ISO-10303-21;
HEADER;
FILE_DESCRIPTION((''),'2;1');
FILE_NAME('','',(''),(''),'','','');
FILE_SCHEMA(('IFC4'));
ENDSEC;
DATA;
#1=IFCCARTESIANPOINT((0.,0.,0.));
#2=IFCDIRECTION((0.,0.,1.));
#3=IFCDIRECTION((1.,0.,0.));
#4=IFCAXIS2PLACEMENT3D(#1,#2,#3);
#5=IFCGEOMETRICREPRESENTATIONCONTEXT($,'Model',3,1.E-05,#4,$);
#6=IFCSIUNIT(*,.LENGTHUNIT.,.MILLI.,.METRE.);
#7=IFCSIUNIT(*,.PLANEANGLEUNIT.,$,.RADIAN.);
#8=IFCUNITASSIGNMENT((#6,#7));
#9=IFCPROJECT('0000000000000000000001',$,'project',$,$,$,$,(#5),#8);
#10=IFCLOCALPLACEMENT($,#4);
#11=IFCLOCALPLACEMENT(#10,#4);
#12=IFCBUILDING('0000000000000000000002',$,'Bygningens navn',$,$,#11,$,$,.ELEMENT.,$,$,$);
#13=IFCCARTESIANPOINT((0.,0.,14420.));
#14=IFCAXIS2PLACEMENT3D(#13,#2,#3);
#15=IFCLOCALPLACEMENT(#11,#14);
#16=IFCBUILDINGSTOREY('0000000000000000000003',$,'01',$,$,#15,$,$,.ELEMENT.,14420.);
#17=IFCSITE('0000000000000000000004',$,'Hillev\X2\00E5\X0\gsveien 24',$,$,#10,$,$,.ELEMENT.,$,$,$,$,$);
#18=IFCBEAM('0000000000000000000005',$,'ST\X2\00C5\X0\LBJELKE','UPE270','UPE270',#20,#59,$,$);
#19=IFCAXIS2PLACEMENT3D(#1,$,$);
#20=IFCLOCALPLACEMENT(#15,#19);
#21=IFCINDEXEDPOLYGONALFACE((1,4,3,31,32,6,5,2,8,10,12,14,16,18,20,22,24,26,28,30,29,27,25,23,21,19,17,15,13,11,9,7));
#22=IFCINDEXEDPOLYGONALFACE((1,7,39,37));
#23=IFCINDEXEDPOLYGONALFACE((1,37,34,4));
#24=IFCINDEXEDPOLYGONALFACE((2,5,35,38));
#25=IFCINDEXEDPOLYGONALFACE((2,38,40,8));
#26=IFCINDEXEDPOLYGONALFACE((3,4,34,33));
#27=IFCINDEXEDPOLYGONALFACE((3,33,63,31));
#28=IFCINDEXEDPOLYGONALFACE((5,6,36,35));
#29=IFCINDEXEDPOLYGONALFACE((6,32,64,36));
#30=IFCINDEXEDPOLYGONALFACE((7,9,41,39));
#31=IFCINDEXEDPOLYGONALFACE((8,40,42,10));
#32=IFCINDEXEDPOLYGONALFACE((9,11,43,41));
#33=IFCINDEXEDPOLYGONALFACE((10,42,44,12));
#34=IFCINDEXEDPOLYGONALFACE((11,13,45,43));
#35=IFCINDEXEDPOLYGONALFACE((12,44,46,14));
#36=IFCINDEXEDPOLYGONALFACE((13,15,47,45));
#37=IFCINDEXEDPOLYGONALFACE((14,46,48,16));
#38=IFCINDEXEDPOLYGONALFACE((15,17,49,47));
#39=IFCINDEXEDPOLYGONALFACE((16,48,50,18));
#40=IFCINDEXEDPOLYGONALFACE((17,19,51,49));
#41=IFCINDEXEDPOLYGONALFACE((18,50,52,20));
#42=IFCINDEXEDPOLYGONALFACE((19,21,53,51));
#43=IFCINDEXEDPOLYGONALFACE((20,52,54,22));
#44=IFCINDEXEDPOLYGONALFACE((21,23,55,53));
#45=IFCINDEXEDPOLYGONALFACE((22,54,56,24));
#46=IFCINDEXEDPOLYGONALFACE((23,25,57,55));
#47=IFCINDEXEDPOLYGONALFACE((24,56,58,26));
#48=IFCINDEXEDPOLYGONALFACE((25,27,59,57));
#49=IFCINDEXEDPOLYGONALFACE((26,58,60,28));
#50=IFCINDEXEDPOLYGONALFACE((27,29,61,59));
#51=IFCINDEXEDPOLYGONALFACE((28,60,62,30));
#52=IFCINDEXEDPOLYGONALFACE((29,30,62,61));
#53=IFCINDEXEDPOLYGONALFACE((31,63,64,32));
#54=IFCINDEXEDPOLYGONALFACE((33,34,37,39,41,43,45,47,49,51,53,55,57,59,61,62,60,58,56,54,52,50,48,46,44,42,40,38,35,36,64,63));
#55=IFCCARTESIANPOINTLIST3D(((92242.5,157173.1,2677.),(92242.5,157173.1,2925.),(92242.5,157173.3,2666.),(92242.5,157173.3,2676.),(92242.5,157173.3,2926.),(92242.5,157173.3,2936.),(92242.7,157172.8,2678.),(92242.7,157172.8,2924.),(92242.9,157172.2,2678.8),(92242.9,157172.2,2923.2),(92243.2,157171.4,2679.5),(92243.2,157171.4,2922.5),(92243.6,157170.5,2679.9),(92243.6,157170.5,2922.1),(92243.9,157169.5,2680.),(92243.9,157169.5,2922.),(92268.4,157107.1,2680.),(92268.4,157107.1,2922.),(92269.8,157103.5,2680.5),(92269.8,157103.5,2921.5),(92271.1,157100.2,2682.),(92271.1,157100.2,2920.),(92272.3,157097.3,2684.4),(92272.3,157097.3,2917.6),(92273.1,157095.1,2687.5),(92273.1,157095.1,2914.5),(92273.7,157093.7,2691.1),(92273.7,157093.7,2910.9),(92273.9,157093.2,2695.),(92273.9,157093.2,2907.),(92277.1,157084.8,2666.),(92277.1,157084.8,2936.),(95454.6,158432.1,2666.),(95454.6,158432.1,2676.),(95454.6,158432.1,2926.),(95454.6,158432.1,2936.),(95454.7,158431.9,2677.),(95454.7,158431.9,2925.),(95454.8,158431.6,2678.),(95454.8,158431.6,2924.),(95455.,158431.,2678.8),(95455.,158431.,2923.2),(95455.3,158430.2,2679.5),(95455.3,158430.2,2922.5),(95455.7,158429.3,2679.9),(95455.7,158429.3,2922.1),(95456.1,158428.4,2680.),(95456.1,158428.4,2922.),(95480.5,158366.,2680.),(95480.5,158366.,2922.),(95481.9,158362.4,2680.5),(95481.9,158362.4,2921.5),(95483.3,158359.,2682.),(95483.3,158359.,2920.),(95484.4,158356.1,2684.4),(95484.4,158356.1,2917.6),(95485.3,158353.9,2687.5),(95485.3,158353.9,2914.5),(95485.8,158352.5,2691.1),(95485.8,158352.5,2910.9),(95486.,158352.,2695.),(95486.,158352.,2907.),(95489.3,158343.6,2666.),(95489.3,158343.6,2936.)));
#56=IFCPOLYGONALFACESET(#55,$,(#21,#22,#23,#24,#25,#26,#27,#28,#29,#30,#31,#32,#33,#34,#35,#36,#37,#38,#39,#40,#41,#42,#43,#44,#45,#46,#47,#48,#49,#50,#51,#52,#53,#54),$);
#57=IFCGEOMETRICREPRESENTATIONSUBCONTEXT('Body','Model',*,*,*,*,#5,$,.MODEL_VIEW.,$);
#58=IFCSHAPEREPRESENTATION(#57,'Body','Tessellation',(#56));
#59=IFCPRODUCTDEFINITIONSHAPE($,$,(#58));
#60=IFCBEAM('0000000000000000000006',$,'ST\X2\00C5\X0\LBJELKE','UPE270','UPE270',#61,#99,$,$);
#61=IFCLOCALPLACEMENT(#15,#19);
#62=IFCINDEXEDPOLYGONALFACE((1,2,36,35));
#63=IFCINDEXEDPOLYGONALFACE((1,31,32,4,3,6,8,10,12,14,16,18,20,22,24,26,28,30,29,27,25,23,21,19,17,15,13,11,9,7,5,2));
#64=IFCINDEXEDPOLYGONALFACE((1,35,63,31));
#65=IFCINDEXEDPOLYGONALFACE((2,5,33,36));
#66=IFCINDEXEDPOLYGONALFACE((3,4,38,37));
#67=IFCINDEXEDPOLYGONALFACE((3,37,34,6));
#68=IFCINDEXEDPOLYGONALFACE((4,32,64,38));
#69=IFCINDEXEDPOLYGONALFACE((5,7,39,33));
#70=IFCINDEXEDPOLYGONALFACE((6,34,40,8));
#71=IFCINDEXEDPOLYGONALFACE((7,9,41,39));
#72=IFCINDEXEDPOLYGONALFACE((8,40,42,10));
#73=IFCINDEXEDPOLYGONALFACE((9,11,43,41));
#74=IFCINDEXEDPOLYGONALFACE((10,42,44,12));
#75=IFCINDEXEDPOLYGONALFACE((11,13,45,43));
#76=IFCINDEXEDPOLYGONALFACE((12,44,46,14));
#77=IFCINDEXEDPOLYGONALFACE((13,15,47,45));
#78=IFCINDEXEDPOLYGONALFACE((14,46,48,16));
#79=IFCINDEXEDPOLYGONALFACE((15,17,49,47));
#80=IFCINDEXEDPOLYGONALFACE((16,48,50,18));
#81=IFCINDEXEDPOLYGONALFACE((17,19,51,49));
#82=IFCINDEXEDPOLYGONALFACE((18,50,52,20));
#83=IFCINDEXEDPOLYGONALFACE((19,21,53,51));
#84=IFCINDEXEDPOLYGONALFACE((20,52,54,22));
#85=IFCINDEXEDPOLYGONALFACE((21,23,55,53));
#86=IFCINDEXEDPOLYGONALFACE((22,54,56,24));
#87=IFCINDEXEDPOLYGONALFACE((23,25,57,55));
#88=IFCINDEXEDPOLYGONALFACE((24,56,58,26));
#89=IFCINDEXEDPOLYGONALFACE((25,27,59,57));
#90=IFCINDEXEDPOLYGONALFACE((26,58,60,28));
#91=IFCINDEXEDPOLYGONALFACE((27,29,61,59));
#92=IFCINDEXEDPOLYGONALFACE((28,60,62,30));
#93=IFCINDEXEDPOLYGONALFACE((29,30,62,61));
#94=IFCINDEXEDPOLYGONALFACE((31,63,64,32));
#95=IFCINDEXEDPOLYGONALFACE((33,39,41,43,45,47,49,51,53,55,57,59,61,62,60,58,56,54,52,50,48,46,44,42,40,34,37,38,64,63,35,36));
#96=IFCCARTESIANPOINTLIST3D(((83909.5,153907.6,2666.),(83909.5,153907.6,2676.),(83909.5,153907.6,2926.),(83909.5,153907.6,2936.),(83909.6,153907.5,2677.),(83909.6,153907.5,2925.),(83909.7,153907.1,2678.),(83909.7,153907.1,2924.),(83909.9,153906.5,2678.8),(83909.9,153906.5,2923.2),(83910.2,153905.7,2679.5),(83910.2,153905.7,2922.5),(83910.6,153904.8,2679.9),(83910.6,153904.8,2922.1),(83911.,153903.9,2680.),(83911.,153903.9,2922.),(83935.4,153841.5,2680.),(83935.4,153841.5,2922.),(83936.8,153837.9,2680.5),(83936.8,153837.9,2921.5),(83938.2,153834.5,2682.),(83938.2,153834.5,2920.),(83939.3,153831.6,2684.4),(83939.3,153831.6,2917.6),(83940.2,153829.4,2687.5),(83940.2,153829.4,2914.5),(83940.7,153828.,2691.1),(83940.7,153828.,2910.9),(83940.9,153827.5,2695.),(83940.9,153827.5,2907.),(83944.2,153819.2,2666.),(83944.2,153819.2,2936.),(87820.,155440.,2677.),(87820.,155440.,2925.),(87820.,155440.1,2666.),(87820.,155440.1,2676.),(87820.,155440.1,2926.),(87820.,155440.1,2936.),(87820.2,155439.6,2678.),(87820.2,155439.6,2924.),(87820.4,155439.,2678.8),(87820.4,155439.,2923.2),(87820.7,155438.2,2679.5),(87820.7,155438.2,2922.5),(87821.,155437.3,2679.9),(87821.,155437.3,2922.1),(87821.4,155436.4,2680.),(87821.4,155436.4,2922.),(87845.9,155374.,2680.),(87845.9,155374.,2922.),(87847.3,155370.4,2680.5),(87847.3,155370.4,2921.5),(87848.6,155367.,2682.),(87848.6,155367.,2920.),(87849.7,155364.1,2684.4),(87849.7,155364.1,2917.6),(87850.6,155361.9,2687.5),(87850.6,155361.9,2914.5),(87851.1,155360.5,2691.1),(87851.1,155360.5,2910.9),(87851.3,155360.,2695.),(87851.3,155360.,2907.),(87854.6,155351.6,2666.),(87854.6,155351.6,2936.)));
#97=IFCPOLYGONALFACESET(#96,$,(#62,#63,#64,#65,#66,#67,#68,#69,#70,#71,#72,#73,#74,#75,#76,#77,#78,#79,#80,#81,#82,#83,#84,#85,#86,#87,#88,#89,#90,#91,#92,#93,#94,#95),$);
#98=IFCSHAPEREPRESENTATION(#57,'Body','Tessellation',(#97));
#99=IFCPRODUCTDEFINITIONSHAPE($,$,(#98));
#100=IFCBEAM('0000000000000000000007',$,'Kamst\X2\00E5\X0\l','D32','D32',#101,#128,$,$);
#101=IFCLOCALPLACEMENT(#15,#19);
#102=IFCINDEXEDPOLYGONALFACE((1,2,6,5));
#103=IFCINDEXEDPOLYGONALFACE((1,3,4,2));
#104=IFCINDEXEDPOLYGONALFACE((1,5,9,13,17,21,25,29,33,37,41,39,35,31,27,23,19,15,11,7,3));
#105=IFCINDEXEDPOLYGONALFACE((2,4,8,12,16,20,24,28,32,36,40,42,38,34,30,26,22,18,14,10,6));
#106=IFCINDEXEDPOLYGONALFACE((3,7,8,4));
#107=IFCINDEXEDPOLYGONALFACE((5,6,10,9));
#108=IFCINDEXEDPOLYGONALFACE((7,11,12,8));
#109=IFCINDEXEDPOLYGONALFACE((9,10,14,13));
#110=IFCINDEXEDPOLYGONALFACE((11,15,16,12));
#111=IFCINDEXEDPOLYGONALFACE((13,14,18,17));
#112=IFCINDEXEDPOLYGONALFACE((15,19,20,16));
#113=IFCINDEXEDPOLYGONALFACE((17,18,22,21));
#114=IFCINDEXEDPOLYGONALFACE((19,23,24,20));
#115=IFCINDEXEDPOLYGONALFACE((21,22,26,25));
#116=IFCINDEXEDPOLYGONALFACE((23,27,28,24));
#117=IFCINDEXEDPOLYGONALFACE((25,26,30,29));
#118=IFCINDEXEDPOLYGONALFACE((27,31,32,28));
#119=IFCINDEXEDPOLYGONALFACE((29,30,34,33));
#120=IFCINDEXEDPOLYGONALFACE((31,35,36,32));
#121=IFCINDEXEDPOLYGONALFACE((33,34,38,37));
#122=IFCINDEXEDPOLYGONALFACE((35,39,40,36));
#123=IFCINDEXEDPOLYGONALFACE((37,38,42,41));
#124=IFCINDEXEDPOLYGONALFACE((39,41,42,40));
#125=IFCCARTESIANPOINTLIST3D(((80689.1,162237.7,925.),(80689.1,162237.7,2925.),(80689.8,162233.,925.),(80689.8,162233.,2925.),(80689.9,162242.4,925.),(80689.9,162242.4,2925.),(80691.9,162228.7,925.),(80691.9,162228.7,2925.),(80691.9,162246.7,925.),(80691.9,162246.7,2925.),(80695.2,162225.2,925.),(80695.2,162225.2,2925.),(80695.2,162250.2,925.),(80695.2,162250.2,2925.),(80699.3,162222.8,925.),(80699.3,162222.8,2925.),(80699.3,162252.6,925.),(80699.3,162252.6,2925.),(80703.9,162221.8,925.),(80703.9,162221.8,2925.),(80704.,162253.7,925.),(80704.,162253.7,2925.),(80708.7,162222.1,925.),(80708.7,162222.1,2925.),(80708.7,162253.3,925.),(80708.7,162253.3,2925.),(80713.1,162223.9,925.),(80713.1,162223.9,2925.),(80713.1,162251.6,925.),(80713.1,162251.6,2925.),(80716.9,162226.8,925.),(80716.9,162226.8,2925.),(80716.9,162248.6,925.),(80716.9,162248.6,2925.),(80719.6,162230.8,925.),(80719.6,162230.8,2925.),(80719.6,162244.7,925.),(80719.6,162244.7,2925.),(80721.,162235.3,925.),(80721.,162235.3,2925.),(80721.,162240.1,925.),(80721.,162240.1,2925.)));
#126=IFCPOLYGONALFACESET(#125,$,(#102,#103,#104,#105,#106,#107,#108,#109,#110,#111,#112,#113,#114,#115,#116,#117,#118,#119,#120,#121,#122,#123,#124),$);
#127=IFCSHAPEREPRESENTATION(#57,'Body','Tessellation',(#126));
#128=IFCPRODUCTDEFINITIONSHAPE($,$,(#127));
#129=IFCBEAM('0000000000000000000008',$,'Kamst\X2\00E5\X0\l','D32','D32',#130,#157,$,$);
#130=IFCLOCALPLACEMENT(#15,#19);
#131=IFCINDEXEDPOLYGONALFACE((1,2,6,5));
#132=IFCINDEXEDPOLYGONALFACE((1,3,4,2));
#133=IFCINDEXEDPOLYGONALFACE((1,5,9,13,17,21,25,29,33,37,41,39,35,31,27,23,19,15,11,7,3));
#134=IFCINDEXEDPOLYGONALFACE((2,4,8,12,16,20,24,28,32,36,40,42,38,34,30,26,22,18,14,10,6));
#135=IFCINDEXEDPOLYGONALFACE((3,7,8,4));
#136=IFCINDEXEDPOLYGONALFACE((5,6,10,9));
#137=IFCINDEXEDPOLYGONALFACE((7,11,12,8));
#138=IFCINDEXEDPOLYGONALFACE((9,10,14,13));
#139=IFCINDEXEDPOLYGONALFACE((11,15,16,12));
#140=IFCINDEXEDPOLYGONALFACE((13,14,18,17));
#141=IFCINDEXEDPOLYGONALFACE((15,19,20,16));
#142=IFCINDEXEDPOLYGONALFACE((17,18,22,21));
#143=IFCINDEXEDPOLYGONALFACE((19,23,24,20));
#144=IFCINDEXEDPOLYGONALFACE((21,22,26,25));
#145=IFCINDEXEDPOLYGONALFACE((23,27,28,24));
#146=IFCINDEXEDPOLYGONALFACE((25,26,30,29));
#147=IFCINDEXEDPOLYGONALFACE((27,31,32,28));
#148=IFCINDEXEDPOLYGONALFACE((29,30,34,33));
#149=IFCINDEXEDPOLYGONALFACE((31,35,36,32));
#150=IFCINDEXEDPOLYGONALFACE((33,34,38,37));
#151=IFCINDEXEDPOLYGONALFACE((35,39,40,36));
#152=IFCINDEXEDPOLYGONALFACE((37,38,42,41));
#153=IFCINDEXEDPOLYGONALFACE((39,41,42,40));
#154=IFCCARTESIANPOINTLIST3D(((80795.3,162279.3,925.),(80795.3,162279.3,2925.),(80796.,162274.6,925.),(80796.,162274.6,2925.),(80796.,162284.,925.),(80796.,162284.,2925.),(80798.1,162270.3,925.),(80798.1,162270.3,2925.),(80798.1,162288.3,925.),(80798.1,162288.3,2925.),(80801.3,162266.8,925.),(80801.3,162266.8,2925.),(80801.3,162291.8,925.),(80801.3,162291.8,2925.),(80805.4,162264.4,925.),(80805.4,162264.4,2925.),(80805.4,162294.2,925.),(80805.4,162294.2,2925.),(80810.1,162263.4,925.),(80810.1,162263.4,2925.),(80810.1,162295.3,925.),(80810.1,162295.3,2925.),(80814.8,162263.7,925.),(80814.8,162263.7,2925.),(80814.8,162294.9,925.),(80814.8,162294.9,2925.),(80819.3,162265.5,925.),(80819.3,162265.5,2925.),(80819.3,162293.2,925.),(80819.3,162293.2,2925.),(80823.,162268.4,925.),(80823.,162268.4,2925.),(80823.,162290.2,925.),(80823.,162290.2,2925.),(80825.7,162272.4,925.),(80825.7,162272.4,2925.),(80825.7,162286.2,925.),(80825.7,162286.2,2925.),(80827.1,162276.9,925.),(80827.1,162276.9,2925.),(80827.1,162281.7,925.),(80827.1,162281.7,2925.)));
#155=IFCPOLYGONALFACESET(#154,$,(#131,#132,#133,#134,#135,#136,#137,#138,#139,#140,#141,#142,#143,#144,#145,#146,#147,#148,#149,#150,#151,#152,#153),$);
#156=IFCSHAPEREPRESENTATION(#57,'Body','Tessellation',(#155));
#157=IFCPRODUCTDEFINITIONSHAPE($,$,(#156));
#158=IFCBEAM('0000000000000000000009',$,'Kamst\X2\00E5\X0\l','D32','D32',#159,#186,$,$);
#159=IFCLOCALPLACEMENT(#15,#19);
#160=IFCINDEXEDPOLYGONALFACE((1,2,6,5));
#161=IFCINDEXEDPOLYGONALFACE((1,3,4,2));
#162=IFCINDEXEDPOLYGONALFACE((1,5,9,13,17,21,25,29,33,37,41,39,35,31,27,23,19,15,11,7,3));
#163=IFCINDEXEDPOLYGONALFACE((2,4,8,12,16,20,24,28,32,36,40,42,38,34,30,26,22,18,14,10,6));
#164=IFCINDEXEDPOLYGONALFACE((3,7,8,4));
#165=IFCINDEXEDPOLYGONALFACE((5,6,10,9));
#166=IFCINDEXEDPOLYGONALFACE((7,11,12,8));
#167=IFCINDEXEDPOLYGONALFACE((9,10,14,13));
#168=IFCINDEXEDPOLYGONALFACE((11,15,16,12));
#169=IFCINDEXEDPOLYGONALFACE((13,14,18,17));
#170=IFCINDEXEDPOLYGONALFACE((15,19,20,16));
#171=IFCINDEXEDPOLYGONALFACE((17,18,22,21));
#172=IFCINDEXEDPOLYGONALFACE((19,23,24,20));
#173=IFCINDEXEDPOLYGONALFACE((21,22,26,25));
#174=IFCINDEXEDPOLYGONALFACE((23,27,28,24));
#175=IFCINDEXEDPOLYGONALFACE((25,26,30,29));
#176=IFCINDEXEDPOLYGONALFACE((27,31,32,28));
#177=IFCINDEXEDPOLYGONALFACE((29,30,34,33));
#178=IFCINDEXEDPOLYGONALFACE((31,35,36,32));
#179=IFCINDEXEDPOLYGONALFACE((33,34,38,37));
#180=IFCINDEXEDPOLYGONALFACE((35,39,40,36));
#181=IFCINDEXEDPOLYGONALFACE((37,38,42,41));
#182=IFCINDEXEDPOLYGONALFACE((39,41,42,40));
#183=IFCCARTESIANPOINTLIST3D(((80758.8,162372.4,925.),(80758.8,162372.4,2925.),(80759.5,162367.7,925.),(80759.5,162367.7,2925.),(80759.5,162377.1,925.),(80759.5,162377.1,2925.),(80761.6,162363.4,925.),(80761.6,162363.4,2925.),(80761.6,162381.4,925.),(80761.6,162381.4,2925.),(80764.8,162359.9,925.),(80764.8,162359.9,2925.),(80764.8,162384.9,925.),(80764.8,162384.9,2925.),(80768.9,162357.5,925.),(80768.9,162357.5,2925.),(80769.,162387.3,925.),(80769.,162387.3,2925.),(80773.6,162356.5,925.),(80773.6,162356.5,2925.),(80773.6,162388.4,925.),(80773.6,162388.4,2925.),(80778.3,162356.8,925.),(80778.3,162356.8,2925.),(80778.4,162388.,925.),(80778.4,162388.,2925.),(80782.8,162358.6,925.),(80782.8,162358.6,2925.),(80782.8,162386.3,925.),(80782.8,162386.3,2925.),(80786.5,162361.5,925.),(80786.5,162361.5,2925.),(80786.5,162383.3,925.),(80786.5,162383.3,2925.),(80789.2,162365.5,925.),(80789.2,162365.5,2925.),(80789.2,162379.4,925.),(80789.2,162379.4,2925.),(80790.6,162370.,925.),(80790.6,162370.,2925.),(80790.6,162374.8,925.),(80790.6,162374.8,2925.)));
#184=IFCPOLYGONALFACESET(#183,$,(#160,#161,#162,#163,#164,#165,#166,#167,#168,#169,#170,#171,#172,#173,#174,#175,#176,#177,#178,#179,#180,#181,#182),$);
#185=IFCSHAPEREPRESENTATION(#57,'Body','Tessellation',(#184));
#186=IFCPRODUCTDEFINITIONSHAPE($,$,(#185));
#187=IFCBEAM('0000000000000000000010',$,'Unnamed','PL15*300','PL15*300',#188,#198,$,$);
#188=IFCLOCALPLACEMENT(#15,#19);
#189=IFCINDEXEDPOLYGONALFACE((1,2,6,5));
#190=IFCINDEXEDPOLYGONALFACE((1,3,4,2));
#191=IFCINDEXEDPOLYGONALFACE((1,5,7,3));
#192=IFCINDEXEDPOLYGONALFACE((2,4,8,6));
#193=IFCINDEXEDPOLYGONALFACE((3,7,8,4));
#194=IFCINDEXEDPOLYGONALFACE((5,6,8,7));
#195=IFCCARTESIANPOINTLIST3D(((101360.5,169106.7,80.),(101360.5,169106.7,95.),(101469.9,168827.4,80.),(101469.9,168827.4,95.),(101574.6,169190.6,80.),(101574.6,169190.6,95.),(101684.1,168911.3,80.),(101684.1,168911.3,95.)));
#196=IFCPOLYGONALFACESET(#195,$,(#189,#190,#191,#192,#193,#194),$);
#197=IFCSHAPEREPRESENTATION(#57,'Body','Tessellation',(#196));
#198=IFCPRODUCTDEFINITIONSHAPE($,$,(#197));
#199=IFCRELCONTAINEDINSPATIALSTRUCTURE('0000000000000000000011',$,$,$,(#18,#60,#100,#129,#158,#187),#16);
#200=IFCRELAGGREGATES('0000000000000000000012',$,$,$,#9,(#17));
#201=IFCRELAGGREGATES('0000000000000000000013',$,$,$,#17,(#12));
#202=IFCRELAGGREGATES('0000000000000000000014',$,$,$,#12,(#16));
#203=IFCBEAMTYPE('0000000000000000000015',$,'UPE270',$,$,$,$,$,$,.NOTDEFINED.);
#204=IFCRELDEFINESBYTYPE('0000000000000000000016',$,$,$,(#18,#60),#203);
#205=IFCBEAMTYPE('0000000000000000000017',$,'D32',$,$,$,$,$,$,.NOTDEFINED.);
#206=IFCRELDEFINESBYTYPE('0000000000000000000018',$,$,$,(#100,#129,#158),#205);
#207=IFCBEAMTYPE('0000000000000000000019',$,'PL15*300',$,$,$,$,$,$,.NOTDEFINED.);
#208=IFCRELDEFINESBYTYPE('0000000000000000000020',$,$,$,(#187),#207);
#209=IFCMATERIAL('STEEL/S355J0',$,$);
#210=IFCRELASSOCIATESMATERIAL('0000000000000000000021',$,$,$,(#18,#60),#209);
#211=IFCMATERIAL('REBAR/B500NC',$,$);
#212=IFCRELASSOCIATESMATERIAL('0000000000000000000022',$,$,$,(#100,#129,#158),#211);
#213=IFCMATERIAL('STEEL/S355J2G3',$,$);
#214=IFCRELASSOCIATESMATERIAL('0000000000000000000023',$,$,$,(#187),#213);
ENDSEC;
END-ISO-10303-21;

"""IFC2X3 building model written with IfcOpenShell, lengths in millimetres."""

from ifc_helpers import new_model, si_unit, frame, frame_2d, origin_with_axes, place, context, subcontext, project, spatial, rectangle, circle, u_section, extrude, material, type_object, element, save


model = new_model("IFC2X3")

# Units and contexts
model_context = context("Model", 3, precision=1e-05, world=origin_with_axes())
body_context = subcontext(model_context, "Body", "Model", "MODEL_VIEW")
ifc_project = project(units=[si_unit("LENGTHUNIT", "METRE", prefix="MILLI"), si_unit("PLANEANGLEUNIT", "RADIAN")], contexts=[model_context])

# Site, building, storey
site_placement = place(None, origin_with_axes())
site = spatial("IfcSite", under=ifc_project, at=site_placement, Name="Hillevågsveien 24", CompositionType="ELEMENT")
building_placement = place(site_placement, origin_with_axes())
building = spatial("IfcBuilding", under=site, at=building_placement, Name="Bygningens navn", CompositionType="ELEMENT")
storey_placement = place(building_placement, frame((0.0, 0.0, 14420.0), z_axis=(0.0, 0.0, 1.0), x_axis=(1.0, 0.0, 0.0)))
storey = spatial("IfcBuildingStorey", under=building, at=storey_placement, Name="01", CompositionType="ELEMENT", Elevation=14420.0)

# Shared definitions
ifc_material_1 = material(Name="STEEL/S355J0")

# Beams
ifc_material_2 = material(Name="REBAR/B500NC")
beam_type_1 = type_object("IfcBeamType", Name="UPE270", PredefinedType="NOTDEFINED")
beam_1_placement = place(storey_placement, frame((92259.8, 157129.0, 2801.0), z_axis=(0.0, 0.0, -1.0), x_axis=(0.931056, 0.364877, 0.0)))
element("IfcBeam", 1, at=beam_1_placement, inside=storey, type_object=beam_type_1, material=ifc_material_1, Name="STÅLBJELKE", Description="UPE270", ObjectType="UPE270", context=body_context, shape_type="SweptSolid", body=[
    extrude(u_section(Depth=270.0, FlangeWidth=95.0, WebThickness=9.0, FlangeThickness=14.0, FilletRadius=15.0, EdgeRadius=4.0, at=frame_2d((0.0, 0.0), x_axis=(1.0, 0.0))), frame((3450.0, 0.0, 0.0), z_axis=(-1.0, 0.0, 0.0), x_axis=(0.0, -1.0, 0.0)), (0.0, 0.0, 1.0), 3450.0),
])
beam_2_placement = place(storey_placement, frame((83926.8, 153863.4, 2801.0), z_axis=(0.0, 0.0, -1.0), x_axis=(0.931056, 0.364877, 0.0)))
element("IfcBeam", 2, at=beam_2_placement, inside=storey, type_object=beam_type_1, material=ifc_material_1, Name="STÅLBJELKE", Description="UPE270", ObjectType="UPE270", context=body_context, shape_type="SweptSolid", body=[
    extrude(u_section(Depth=270.0, FlangeWidth=95.0, WebThickness=9.0, FlangeThickness=14.0, FilletRadius=15.0, EdgeRadius=4.0, at=frame_2d((0.0, 0.0), x_axis=(1.0, 0.0))), frame((4200.0, 0.0, 0.0), z_axis=(-1.0, 0.0, 0.0), x_axis=(0.0, -1.0, 0.0)), (0.0, 0.0, 1.0), 4200.0),
])
beam_type_2 = type_object("IfcBeamType", Name="D32", PredefinedType="NOTDEFINED")
for number, where, z_axis, x_axis, name in (
    (3, (80705.1, 162237.7, 2925.0), (-0.931056, -0.364877, 0.0), (0.0, 0.0, -1.0), "Kamstål"),
    (4, (80811.3, 162279.3, 2925.0), (-0.931056, -0.364877, 0.0), (0.0, 0.0, -1.0), "Kamstål"),
    (5, (80774.8, 162372.4, 2925.0), (-0.931056, -0.364877, 0.0), (0.0, 0.0, -1.0), "Kamstål"),
):
    element("IfcBeam", number, at=place(storey_placement, frame(where, z_axis=z_axis, x_axis=x_axis)), inside=storey, type_object=beam_type_2, material=ifc_material_2, Name=name, Description="D32", ObjectType="D32", context=body_context, shape_type="SweptSolid", body=[
        extrude(circle(Radius=16.0, at=frame_2d((0.0, 0.0), x_axis=(1.0, 0.0))), frame((2000.0, 0.0, 0.0), z_axis=(-1.0, 0.0, 0.0), x_axis=(0.0, -1.0, 0.0)), (0.0, 0.0, 1.0), 2000.0),
    ])
ifc_material_3 = material(Name="STEEL/S355J2G3")
beam_type_3 = type_object("IfcBeamType", Name="PL15*300", PredefinedType="NOTDEFINED")
beam_3_placement = place(storey_placement, frame((101415.2, 168967.1, 87.5), z_axis=(-0.364877, 0.931056, 0.0), x_axis=(0.931056, 0.364877, 0.0)))
element("IfcBeam", 6, at=beam_3_placement, inside=storey, type_object=beam_type_3, material=ifc_material_3, Name="Unnamed", Description="PL15*300", ObjectType="PL15*300", context=body_context, shape_type="SweptSolid", body=[
    extrude(rectangle(XDim=15.0, YDim=300.0, at=frame_2d((0.0, 0.0), x_axis=(1.0, 0.0))), frame((230.0, 0.0, 0.0), z_axis=(-1.0, 0.0, 0.0), x_axis=(0.0, -1.0, 0.0)), (0.0, 0.0, 1.0), 230.0),
])

save(model, "model.ifc")
